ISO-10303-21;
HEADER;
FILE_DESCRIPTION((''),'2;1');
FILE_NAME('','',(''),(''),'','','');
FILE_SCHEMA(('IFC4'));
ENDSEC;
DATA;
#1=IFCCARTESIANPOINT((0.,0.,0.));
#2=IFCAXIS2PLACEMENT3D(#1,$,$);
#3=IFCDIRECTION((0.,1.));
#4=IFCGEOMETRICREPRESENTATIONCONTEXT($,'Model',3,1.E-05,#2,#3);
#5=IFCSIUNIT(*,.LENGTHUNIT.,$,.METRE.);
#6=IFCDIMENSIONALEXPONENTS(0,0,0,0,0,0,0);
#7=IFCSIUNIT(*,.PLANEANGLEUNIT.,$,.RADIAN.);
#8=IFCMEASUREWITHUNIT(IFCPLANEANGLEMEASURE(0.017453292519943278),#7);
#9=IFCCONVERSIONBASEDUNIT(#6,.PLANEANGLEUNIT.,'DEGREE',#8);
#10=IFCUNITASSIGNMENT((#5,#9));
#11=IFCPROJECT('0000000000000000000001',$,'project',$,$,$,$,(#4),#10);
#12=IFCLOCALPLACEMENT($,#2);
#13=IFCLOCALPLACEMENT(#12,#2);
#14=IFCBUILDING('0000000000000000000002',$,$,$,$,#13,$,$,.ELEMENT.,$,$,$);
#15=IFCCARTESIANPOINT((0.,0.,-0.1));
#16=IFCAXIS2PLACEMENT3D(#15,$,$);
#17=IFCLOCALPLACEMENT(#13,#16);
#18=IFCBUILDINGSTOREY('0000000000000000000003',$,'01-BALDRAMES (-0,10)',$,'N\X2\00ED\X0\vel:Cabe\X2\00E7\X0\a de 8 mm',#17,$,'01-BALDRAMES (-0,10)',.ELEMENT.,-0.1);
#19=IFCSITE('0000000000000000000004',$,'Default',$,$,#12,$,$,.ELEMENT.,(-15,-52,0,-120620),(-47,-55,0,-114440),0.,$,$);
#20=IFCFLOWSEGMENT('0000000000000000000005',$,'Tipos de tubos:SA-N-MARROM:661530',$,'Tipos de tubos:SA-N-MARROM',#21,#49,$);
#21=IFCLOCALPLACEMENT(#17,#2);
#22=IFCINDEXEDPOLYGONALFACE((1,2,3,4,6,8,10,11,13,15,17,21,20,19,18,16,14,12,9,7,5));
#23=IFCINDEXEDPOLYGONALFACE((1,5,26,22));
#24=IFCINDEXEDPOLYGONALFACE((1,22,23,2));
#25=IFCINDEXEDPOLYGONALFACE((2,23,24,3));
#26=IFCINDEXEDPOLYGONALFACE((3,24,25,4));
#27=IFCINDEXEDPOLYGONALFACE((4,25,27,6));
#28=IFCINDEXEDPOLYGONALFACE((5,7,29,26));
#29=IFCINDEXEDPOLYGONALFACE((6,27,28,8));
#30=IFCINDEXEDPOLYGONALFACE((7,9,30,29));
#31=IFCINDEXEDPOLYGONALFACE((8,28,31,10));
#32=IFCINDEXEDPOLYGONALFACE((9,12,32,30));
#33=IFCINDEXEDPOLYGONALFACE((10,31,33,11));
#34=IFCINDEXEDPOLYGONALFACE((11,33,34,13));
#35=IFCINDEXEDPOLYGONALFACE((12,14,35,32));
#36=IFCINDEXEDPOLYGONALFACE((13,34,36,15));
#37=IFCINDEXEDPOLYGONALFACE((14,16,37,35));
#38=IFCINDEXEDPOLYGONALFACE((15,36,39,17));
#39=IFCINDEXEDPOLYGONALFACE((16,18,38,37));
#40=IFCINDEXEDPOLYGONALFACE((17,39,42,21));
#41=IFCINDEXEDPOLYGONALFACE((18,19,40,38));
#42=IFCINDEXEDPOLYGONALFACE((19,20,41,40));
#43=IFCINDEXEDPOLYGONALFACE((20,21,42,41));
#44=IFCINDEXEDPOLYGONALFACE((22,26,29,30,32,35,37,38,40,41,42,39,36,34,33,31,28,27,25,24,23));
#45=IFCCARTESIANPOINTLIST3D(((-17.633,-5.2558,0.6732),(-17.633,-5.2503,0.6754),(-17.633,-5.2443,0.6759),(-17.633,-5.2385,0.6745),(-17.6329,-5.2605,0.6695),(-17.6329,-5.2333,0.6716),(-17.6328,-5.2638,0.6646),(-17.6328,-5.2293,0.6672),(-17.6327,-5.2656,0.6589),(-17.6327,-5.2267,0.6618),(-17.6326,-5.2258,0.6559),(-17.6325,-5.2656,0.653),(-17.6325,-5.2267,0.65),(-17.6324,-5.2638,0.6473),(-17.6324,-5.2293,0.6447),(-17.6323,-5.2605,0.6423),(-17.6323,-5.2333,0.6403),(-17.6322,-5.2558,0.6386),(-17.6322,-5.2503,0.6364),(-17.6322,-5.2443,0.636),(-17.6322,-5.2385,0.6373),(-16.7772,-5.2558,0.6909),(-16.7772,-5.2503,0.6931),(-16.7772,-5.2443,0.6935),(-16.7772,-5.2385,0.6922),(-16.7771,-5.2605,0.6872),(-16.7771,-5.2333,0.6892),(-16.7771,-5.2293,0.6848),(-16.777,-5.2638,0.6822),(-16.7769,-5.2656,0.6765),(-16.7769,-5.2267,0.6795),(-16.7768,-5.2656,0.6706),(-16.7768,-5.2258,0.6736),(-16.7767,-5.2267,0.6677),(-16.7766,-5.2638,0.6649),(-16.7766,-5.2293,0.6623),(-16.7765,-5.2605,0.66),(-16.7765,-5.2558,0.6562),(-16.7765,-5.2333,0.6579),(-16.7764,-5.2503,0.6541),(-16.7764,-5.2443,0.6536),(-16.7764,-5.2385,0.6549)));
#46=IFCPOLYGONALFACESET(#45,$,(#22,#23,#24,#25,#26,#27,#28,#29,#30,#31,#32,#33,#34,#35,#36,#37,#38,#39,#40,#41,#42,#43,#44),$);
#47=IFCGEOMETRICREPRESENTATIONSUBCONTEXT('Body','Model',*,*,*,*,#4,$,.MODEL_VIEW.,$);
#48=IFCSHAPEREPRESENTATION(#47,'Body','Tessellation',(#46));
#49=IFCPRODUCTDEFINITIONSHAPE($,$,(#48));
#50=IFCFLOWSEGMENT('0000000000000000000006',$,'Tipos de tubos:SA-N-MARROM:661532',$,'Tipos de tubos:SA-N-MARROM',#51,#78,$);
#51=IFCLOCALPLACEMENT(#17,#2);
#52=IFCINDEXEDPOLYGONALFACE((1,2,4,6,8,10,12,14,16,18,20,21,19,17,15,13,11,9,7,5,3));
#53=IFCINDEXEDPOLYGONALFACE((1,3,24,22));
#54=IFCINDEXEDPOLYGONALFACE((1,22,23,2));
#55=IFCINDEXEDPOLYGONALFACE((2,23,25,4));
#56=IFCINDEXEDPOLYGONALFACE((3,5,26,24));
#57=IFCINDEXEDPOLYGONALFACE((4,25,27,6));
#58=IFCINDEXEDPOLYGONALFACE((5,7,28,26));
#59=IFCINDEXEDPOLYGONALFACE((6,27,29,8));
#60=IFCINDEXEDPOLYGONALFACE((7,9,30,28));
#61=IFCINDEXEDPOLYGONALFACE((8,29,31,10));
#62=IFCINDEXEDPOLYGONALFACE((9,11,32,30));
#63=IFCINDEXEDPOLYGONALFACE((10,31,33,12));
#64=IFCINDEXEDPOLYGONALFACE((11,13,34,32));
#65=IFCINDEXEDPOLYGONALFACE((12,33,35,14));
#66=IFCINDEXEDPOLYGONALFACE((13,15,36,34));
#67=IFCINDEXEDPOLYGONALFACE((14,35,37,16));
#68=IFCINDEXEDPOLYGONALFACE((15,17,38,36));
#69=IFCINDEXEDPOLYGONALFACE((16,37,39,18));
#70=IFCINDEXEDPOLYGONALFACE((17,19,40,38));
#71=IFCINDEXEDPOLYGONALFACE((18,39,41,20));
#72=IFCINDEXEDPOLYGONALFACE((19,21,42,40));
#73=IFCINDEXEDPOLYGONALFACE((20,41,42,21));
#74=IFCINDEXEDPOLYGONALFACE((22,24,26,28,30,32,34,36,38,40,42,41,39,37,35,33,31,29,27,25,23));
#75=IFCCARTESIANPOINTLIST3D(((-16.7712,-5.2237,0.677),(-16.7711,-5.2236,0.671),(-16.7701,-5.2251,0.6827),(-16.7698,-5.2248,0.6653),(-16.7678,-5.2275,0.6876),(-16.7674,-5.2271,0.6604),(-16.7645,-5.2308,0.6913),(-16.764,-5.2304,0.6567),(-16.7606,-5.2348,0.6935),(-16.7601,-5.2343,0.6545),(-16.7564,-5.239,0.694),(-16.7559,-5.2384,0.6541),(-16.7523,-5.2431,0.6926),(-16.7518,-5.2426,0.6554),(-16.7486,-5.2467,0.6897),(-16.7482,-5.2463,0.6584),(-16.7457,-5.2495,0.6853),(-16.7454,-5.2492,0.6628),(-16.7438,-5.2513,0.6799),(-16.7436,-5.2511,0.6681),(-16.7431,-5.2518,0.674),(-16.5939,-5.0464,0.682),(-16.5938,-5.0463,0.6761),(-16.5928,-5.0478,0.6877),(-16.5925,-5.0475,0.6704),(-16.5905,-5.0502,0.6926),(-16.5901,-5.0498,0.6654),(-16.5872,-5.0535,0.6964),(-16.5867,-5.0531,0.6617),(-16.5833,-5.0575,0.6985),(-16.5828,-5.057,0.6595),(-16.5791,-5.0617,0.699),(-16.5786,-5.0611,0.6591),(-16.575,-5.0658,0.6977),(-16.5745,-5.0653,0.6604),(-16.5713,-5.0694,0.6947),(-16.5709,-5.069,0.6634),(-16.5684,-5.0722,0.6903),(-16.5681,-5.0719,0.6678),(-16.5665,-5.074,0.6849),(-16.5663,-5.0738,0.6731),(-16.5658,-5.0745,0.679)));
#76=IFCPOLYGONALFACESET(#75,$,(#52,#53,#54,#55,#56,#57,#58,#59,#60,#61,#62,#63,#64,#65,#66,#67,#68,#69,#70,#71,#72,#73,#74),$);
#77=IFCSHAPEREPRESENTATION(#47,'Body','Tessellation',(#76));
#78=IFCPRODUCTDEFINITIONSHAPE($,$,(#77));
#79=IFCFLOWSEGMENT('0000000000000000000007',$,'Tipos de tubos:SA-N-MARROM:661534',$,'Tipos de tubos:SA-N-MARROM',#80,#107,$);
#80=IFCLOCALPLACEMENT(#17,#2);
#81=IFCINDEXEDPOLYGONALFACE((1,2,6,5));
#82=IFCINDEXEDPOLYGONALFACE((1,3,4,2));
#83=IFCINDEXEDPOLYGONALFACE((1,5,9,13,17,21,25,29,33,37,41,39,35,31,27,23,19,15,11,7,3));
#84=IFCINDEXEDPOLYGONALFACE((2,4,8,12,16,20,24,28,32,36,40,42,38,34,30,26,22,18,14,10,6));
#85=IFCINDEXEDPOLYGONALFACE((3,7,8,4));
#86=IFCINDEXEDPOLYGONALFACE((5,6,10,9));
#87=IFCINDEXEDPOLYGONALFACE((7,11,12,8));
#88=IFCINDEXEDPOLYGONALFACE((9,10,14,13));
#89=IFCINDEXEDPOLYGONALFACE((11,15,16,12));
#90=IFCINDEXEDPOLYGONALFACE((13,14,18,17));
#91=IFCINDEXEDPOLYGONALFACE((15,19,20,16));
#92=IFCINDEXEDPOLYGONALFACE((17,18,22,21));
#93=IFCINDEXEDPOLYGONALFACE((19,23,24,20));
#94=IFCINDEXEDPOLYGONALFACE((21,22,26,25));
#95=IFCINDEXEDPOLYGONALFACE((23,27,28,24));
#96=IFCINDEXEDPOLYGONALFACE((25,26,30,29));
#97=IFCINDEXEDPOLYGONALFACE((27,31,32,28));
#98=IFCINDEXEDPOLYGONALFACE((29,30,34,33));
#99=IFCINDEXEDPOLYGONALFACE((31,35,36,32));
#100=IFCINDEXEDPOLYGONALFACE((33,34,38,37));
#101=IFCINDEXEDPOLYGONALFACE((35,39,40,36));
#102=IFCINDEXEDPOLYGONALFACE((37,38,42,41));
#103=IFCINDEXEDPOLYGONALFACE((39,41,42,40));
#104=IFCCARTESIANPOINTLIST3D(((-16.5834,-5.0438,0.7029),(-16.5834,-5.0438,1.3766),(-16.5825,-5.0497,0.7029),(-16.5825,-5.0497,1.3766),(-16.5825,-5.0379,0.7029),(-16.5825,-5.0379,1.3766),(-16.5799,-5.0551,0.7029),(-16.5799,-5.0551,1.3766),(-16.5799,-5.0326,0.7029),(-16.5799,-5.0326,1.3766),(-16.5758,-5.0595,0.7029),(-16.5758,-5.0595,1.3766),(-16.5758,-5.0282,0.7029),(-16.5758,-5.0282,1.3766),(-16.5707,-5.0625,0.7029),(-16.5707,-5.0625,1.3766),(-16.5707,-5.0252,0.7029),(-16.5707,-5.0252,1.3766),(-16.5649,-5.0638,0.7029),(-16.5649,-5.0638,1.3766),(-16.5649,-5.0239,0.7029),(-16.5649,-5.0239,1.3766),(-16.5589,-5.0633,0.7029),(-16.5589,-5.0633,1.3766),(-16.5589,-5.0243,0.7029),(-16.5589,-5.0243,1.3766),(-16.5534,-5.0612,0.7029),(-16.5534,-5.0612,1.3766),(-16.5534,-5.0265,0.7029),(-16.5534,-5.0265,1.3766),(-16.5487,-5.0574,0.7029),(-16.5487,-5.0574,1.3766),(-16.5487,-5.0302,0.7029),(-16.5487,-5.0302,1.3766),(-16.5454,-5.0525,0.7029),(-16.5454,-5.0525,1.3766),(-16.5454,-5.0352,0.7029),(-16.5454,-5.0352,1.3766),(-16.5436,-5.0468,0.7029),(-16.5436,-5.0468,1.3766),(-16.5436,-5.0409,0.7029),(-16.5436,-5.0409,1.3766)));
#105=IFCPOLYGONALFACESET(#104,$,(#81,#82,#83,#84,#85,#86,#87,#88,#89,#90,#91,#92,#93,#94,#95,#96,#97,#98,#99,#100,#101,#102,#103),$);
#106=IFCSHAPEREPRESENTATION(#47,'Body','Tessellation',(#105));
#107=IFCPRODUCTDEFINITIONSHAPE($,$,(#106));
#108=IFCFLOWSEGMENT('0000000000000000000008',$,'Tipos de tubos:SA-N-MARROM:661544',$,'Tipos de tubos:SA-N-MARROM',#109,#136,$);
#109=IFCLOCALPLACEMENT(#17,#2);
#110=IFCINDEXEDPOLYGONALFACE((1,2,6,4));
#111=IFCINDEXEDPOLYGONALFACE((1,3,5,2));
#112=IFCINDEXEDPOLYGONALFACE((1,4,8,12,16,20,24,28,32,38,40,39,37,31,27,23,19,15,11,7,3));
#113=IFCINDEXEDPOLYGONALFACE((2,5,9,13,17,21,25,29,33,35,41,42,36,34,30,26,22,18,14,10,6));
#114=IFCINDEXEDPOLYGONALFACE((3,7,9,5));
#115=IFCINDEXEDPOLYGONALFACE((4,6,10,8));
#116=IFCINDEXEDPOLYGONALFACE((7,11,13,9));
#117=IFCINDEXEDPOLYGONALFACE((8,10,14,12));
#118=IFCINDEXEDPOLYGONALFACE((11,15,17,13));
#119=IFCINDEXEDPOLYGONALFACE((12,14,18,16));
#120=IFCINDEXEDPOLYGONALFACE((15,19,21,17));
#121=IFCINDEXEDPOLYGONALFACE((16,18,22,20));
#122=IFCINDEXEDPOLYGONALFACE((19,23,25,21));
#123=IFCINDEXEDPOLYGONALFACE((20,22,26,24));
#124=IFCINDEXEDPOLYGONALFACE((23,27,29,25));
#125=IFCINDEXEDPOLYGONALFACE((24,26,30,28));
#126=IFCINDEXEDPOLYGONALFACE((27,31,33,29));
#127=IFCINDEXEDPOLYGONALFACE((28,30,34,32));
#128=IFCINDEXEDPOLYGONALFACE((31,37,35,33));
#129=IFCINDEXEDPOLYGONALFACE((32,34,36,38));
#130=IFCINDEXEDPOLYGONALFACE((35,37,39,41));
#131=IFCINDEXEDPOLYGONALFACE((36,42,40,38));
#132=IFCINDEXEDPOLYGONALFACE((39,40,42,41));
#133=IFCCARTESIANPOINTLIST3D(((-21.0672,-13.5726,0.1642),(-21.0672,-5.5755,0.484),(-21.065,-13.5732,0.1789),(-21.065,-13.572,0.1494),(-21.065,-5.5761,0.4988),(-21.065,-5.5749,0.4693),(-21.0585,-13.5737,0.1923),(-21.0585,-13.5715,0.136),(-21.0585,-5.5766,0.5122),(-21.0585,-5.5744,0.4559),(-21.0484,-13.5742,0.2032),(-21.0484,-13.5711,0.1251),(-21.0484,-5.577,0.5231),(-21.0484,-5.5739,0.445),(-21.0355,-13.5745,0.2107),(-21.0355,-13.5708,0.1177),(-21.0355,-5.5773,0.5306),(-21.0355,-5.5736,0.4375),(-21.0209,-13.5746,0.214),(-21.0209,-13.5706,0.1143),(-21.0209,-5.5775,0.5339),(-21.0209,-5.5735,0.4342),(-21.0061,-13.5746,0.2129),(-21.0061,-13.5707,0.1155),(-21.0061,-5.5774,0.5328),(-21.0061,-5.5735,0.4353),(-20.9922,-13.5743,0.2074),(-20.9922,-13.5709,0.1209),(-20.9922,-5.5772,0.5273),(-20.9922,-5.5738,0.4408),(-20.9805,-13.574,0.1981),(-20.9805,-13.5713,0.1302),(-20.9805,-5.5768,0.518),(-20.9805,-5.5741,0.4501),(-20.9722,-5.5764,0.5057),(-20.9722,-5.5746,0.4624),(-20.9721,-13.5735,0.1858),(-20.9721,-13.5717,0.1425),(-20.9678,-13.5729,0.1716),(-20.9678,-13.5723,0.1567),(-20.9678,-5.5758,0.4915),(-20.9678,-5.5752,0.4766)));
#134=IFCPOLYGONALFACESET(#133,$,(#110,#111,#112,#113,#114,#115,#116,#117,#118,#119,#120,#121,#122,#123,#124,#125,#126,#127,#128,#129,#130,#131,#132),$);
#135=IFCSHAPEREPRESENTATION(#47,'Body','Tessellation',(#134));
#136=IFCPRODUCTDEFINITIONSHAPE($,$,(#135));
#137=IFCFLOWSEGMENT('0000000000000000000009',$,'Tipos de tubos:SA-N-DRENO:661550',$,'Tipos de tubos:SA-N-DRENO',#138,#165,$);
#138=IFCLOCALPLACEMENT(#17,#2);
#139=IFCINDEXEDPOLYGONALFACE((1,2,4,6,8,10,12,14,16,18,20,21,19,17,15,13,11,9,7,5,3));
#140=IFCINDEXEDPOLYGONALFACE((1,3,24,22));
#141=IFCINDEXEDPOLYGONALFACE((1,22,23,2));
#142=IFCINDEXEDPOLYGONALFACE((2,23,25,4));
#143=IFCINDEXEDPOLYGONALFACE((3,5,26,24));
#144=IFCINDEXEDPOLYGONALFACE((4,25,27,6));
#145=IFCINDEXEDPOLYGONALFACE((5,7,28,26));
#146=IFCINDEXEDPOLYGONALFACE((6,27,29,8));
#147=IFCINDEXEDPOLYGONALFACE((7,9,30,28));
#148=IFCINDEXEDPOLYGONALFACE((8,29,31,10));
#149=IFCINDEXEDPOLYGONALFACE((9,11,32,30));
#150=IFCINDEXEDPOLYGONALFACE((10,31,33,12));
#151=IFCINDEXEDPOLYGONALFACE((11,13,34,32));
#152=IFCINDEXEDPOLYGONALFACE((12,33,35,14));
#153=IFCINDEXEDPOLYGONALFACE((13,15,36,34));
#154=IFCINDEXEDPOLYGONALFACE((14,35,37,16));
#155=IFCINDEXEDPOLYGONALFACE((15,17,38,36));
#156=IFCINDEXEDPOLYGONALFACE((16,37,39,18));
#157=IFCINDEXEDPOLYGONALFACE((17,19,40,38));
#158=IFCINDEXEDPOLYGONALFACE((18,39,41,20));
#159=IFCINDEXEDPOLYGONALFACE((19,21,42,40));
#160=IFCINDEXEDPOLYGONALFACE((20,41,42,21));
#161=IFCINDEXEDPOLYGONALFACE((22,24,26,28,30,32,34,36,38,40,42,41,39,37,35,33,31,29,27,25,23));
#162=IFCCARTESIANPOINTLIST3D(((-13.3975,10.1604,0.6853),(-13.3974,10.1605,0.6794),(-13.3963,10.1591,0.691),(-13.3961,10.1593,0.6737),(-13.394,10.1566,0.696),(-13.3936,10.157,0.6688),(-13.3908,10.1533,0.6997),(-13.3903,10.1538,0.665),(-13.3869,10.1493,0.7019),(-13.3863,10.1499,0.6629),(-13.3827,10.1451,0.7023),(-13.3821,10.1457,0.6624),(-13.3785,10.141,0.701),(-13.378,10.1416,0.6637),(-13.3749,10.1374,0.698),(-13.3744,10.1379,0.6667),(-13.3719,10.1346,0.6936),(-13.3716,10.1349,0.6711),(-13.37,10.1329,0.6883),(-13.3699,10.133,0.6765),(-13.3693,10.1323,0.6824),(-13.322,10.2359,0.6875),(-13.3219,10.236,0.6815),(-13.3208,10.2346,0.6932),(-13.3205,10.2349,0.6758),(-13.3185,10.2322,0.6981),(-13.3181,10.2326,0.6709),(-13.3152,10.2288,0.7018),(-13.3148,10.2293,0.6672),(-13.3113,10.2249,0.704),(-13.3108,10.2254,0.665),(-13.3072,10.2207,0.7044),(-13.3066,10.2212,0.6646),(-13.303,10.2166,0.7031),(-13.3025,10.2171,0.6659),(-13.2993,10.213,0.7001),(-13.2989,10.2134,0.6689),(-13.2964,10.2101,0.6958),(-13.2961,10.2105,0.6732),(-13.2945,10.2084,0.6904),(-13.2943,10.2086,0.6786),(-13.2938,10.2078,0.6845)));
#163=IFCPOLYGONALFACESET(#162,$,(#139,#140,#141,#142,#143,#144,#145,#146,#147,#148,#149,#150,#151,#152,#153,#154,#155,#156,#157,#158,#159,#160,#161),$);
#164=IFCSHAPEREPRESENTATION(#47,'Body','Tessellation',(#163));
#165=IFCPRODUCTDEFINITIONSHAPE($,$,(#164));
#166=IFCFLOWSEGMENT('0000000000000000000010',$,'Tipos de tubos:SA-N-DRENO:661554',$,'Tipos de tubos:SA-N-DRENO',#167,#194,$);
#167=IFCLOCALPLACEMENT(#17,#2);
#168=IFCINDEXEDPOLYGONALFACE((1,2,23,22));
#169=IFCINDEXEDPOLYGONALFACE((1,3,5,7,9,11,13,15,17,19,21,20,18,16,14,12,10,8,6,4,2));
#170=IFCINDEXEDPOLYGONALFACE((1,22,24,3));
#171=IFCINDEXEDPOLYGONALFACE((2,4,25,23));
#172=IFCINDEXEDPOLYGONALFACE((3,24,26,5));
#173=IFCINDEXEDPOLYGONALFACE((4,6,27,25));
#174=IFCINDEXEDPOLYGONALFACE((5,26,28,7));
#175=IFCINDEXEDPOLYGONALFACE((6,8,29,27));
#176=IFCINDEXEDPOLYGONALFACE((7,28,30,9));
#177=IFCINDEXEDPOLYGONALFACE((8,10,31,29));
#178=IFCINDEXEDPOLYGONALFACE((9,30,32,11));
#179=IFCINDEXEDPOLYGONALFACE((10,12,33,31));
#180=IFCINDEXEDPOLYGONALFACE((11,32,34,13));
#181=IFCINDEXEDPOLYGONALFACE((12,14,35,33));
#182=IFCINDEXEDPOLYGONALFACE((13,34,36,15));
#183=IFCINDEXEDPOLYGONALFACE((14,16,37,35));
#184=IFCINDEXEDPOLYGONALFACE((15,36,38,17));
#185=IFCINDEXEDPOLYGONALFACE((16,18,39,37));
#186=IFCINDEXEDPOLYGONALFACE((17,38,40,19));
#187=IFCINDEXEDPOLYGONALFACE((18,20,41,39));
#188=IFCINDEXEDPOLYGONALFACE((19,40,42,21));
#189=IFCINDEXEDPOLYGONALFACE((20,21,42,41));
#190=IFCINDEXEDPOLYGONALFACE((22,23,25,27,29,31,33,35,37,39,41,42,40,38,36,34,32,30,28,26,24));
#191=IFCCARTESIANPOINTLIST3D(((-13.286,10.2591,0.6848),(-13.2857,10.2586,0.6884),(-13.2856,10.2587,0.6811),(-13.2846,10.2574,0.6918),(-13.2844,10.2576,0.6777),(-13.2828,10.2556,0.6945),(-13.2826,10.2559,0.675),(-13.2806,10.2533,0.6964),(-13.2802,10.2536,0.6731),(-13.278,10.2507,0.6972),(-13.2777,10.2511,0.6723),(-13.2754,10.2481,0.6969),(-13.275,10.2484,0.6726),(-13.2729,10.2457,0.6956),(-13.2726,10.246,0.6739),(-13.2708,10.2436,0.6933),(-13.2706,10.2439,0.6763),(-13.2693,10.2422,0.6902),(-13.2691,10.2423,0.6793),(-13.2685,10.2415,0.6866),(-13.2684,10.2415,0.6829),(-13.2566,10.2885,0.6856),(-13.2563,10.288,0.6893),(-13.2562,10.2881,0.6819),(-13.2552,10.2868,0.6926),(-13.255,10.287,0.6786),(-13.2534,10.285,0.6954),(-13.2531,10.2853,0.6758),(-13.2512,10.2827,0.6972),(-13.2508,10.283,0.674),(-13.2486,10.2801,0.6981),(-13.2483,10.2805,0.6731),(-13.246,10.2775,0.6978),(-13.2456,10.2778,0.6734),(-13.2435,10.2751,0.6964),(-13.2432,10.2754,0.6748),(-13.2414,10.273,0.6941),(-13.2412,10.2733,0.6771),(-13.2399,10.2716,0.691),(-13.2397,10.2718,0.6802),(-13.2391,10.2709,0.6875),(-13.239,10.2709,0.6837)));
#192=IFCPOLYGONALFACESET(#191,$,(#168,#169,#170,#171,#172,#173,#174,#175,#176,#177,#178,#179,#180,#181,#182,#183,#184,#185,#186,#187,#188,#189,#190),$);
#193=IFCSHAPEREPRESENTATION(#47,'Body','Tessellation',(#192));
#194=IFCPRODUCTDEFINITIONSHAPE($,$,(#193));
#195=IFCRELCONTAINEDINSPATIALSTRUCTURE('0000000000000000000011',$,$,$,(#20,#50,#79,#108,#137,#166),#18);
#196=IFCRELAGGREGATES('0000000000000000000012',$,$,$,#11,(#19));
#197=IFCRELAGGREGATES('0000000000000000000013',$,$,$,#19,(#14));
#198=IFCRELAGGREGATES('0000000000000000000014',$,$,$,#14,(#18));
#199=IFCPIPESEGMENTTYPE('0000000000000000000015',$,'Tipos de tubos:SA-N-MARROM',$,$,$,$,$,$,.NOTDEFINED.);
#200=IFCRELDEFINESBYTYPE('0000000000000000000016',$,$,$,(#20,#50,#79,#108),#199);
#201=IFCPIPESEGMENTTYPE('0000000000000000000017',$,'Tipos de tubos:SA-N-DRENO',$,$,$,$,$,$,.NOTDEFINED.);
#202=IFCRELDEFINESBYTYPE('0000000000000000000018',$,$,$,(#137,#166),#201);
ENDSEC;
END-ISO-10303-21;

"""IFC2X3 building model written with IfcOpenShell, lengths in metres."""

from ifc_helpers import new_model, entity, si_unit, converted_unit, direction, frame, frame_2d, origin, origin_2d_with_axis, place, context, subcontext, project, spatial, circle, extrude, type_object, element, save


model = new_model("IFC2X3")

# Units and contexts
model_context = context("Model", 3, precision=1e-05, world=origin(), true_north=direction((0.0, 1.0)))
body_context = subcontext(model_context, "Body", "Model", "MODEL_VIEW")
ifc_project = project(units=[si_unit("LENGTHUNIT", "METRE"), converted_unit("PLANEANGLEUNIT", "DEGREE", entity("IfcPlaneAngleMeasure", 0.017453292519943278), si_unit("PLANEANGLEUNIT", "RADIAN"), dimensions=[0, 0, 0, 0, 0, 0, 0])], contexts=[model_context])

# Site, building, storey
site_placement = place(None, origin())
site = spatial("IfcSite", under=ifc_project, at=site_placement, Name="Default", CompositionType="ELEMENT", RefLatitude=(-15, -52, 0, -120620), RefLongitude=(-47, -55, 0, -114440), RefElevation=0.0)
building_placement = place(site_placement, origin())
building = spatial("IfcBuilding", under=site, at=building_placement, CompositionType="ELEMENT")
storey_placement = place(building_placement, frame((0.0, 0.0, -0.1)))
storey = spatial("IfcBuildingStorey", under=building, at=storey_placement, Name="01-BALDRAMES (-0,10)", ObjectType="Nível:Cabeça de 8 mm", LongName="01-BALDRAMES (-0,10)", CompositionType="ELEMENT", Elevation=-0.1)

# Flow segments
pipe_segment_type_1 = type_object("IfcPipeSegmentType", Name="Tipos de tubos:SA-N-MARROM", PredefinedType="NOTDEFINED")
flow_segment_1_placement = place(storey_placement, origin())
element("IfcFlowSegment", 1, at=flow_segment_1_placement, inside=storey, type_object=pipe_segment_type_1, Name="Tipos de tubos:SA-N-MARROM:661530", ObjectType="Tipos de tubos:SA-N-MARROM", context=body_context, shape_type="SweptSolid", body=[
    extrude(circle(Radius=0.02, at=frame_2d((0.0, 0.0), x_axis=(1.0, 0.0))), frame((-17.6326, -5.2458, 0.6559), z_axis=(0.999788, 0.000001, 0.020593), x_axis=(-0.000001, 1.0, 0.0)), (0.0, 0.0, 1.0), 0.856),
])
flow_segment_2_placement = place(storey_placement, origin())
element("IfcFlowSegment", 2, at=flow_segment_2_placement, inside=storey, type_object=pipe_segment_type_1, Name="Tipos de tubos:SA-N-MARROM:661532", ObjectType="Tipos de tubos:SA-N-MARROM", context=body_context, shape_type="SweptSolid", body=[
    extrude(circle(Radius=0.02, at=origin_2d_with_axis()), frame((-16.7572, -5.2377, 0.674), z_axis=(0.706965, 0.706966, 0.019996), x_axis=(0.707107, -0.707106, 0.0)), (0.0, 0.0, 1.0), 0.2508),
])
flow_segment_3_placement = place(storey_placement, origin())
element("IfcFlowSegment", 3, at=flow_segment_3_placement, inside=storey, type_object=pipe_segment_type_1, Name="Tipos de tubos:SA-N-MARROM:661534", ObjectType="Tipos de tubos:SA-N-MARROM", context=body_context, shape_type="SweptSolid", body=[
    extrude(circle(Radius=0.02, at=origin_2d_with_axis()), frame((-16.5634, -5.0438, 0.7029), z_axis=(0.0, 0.0, 1.0), x_axis=(-1.0, 0.0, 0.0)), (0.0, 0.0, 1.0), 0.6737),
])
flow_segment_4_placement = place(storey_placement, origin())
element("IfcFlowSegment", 4, at=flow_segment_4_placement, inside=storey, type_object=pipe_segment_type_1, Name="Tipos de tubos:SA-N-MARROM:661544", ObjectType="Tipos de tubos:SA-N-MARROM", context=body_context, shape_type="SweptSolid", body=[
    extrude(circle(Radius=0.05, at=frame_2d((0.0, 0.0), x_axis=(1.0, 0.0))), frame((-21.0172, -13.5726, 0.1642), z_axis=(-0.000001, 0.999201, 0.039968), x_axis=(-1.0, -0.000001, 0.0)), (0.0, 0.0, 1.0), 8.0035),
])
pipe_segment_type_2 = type_object("IfcPipeSegmentType", Name="Tipos de tubos:SA-N-DRENO", PredefinedType="NOTDEFINED")
flow_segment_5_placement = place(storey_placement, origin())
element("IfcFlowSegment", 5, at=flow_segment_5_placement, inside=storey, type_object=pipe_segment_type_2, Name="Tipos de tubos:SA-N-DRENO:661550", ObjectType="Tipos de tubos:SA-N-DRENO", context=body_context, shape_type="SweptSolid", body=[
    extrude(circle(Radius=0.02, at=origin_2d_with_axis()), frame((-13.3835, 10.1465, 0.6824), z_axis=(0.706965, 0.706966, 0.019996), x_axis=(0.707107, -0.707106, 0.0)), (0.0, 0.0, 1.0), 0.1068),
])
flow_segment_6_placement = place(storey_placement, origin())
element("IfcFlowSegment", 6, at=flow_segment_6_placement, inside=storey, type_object=pipe_segment_type_2, Name="Tipos de tubos:SA-N-DRENO:661554", ObjectType="Tipos de tubos:SA-N-DRENO", context=body_context, shape_type="SweptSolid", body=[
    extrude(circle(Radius=0.0125, at=frame_2d((0.0, 0.0), x_axis=(1.0, 0.0))), frame((-13.2772, 10.2502, 0.6848), z_axis=(0.707036, 0.706895, 0.019996), x_axis=(-0.707037, 0.707177, 0.0)), (0.0, 0.0, 1.0), 0.0416),
])

save(model, "model.ifc")
